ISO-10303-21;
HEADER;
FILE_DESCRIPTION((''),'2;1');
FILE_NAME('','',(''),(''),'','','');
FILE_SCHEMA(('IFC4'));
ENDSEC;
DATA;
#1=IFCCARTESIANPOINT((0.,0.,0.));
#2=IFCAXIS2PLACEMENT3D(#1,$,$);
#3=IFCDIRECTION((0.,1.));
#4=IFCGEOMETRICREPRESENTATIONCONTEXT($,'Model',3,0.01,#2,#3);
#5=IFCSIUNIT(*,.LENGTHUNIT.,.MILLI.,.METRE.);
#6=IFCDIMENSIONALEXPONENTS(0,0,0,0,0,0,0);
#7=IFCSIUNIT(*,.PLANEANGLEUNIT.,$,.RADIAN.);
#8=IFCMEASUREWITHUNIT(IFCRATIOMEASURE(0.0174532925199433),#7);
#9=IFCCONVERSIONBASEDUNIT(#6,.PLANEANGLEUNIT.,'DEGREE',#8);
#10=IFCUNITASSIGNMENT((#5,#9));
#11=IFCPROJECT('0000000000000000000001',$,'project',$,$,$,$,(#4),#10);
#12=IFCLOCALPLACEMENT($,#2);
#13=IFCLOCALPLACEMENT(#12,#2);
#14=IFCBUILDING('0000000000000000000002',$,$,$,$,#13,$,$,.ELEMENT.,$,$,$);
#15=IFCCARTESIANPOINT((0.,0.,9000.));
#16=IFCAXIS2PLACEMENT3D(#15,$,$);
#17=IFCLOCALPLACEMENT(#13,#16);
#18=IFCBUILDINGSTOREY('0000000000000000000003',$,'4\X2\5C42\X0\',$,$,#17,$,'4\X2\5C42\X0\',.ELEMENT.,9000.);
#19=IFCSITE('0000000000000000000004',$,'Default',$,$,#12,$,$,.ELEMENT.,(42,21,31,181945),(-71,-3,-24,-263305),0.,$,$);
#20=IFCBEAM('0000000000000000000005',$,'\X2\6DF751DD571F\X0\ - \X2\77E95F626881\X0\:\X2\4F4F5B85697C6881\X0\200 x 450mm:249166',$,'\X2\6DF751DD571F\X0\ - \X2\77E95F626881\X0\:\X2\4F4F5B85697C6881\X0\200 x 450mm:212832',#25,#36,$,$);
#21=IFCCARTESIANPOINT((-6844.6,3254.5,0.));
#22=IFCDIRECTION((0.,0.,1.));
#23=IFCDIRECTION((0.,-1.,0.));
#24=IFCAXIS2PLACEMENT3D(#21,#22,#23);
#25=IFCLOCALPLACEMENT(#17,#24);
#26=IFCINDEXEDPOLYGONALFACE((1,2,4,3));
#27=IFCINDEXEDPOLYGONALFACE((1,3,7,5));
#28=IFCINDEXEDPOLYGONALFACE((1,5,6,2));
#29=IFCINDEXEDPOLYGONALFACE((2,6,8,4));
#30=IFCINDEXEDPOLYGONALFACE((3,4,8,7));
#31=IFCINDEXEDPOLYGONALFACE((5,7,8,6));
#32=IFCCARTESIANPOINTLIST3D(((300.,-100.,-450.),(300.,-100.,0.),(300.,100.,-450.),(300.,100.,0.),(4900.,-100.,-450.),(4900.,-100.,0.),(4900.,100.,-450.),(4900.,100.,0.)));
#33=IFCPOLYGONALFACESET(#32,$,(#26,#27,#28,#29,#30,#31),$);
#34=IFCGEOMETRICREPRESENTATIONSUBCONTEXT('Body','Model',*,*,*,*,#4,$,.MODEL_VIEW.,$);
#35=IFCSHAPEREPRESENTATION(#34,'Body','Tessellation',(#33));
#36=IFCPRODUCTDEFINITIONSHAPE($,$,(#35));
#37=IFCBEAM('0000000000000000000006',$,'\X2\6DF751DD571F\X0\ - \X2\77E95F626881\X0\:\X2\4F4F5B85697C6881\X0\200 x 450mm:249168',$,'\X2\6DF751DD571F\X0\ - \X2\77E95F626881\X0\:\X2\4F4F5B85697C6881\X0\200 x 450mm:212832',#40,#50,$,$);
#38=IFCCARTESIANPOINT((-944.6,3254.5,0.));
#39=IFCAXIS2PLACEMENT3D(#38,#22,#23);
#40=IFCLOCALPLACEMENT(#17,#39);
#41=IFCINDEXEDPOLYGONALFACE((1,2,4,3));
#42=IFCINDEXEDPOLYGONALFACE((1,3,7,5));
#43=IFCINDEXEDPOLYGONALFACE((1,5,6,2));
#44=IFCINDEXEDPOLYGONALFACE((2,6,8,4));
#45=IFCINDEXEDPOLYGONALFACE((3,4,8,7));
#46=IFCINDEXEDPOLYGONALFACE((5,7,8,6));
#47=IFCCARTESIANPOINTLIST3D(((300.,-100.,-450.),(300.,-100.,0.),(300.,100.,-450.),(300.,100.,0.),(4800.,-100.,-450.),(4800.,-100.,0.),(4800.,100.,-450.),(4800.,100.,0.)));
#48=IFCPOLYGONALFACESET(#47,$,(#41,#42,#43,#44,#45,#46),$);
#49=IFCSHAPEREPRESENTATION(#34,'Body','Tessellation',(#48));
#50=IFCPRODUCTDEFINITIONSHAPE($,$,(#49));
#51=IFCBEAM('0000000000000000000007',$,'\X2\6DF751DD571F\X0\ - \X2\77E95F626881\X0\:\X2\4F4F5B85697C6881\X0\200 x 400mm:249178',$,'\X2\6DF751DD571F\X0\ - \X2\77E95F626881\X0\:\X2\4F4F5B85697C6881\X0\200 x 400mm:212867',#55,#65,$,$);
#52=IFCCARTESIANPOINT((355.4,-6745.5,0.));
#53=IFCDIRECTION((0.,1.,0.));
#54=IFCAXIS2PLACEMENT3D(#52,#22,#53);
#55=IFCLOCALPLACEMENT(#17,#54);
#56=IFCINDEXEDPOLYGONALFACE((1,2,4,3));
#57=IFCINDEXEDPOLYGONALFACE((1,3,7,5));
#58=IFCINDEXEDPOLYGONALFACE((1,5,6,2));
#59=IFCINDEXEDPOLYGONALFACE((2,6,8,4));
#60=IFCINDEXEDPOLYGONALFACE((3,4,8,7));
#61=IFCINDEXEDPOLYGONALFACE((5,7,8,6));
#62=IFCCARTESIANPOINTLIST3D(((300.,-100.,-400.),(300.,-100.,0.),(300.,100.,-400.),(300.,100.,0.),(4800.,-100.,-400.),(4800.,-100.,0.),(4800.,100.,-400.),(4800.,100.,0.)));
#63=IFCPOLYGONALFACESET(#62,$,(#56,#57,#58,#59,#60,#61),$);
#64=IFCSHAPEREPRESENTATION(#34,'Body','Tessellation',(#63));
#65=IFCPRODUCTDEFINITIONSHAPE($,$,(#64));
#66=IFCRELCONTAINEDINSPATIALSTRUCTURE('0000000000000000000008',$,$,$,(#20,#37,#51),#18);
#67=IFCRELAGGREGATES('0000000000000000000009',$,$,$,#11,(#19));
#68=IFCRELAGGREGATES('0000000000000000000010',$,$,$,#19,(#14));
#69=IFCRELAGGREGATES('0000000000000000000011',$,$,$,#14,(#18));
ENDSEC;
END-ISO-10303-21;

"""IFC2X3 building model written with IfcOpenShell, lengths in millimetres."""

from ifc_helpers import new_model, entity, si_unit, converted_unit, direction, frame, frame_2d, origin, place, context, subcontext, project, spatial, rectangle, extrude, element, save


model = new_model("IFC2X3")

# Units and contexts
model_context = context("Model", 3, precision=0.01, world=origin(), true_north=direction((0.0, 1.0)))
body_context = subcontext(model_context, "Body", "Model", "MODEL_VIEW")
ifc_project = project(units=[si_unit("LENGTHUNIT", "METRE", prefix="MILLI"), converted_unit("PLANEANGLEUNIT", "DEGREE", entity("IfcRatioMeasure", 0.0174532925199433), si_unit("PLANEANGLEUNIT", "RADIAN"), dimensions=[0, 0, 0, 0, 0, 0, 0])], contexts=[model_context])

# Site, building, storey
site_placement = place(None, origin())
site = spatial("IfcSite", under=ifc_project, at=site_placement, Name="Default", CompositionType="ELEMENT", RefLatitude=(42, 21, 31, 181945), RefLongitude=(-71, -3, -24, -263305), RefElevation=0.0)
building_placement = place(site_placement, origin())
building = spatial("IfcBuilding", under=site, at=building_placement, CompositionType="ELEMENT")
storey_placement = place(building_placement, frame((0.0, 0.0, 9000.0)))
storey = spatial("IfcBuildingStorey", under=building, at=storey_placement, Name="4层", LongName="4层", CompositionType="ELEMENT", Elevation=9000.0)

# Beams
beam_1_placement = place(storey_placement, frame((-6844.6, 3254.5, 0.0), z_axis=(0.0, 0.0, 1.0), x_axis=(0.0, -1.0, 0.0)))
element("IfcBeam", 1, at=beam_1_placement, inside=storey, Name="混凝土 - 矩形梁:住宅楼梁200 x 450mm:249166", ObjectType="混凝土 - 矩形梁:住宅楼梁200 x 450mm:212832", context=body_context, shape_type="SweptSolid", body=[
    extrude(rectangle(XDim=450.0, YDim=200.0, at=frame_2d((0.0, 0.0), x_axis=(1.0, 0.0))), frame((300.0, 0.0, -225.0), z_axis=(1.0, 0.0, 0.0), x_axis=(0.0, 0.0, -1.0)), (0.0, 0.0, 1.0), 4600.0),
])
beam_2_placement = place(storey_placement, frame((-944.6, 3254.5, 0.0), z_axis=(0.0, 0.0, 1.0), x_axis=(0.0, -1.0, 0.0)))
element("IfcBeam", 2, at=beam_2_placement, inside=storey, Name="混凝土 - 矩形梁:住宅楼梁200 x 450mm:249168", ObjectType="混凝土 - 矩形梁:住宅楼梁200 x 450mm:212832", context=body_context, shape_type="SweptSolid", body=[
    extrude(rectangle(XDim=450.0, YDim=200.0, at=frame_2d((0.0, 0.0), x_axis=(1.0, 0.0))), frame((300.0, 0.0, -225.0), z_axis=(1.0, 0.0, 0.0), x_axis=(0.0, 0.0, -1.0)), (0.0, 0.0, 1.0), 4500.0),
])
beam_3_placement = place(storey_placement, frame((355.4, -6745.5, 0.0), z_axis=(0.0, 0.0, 1.0), x_axis=(0.0, 1.0, 0.0)))
element("IfcBeam", 3, at=beam_3_placement, inside=storey, Name="混凝土 - 矩形梁:住宅楼梁200 x 400mm:249178", ObjectType="混凝土 - 矩形梁:住宅楼梁200 x 400mm:212867", context=body_context, shape_type="SweptSolid", body=[
    extrude(rectangle(XDim=400.0, YDim=200.0, at=frame_2d((0.0, 0.0), x_axis=(1.0, 0.0))), frame((300.0, 0.0, -200.0), z_axis=(1.0, 0.0, 0.0), x_axis=(0.0, 0.0, -1.0)), (0.0, 0.0, 1.0), 4500.0),
])

save(model, "model.ifc")
